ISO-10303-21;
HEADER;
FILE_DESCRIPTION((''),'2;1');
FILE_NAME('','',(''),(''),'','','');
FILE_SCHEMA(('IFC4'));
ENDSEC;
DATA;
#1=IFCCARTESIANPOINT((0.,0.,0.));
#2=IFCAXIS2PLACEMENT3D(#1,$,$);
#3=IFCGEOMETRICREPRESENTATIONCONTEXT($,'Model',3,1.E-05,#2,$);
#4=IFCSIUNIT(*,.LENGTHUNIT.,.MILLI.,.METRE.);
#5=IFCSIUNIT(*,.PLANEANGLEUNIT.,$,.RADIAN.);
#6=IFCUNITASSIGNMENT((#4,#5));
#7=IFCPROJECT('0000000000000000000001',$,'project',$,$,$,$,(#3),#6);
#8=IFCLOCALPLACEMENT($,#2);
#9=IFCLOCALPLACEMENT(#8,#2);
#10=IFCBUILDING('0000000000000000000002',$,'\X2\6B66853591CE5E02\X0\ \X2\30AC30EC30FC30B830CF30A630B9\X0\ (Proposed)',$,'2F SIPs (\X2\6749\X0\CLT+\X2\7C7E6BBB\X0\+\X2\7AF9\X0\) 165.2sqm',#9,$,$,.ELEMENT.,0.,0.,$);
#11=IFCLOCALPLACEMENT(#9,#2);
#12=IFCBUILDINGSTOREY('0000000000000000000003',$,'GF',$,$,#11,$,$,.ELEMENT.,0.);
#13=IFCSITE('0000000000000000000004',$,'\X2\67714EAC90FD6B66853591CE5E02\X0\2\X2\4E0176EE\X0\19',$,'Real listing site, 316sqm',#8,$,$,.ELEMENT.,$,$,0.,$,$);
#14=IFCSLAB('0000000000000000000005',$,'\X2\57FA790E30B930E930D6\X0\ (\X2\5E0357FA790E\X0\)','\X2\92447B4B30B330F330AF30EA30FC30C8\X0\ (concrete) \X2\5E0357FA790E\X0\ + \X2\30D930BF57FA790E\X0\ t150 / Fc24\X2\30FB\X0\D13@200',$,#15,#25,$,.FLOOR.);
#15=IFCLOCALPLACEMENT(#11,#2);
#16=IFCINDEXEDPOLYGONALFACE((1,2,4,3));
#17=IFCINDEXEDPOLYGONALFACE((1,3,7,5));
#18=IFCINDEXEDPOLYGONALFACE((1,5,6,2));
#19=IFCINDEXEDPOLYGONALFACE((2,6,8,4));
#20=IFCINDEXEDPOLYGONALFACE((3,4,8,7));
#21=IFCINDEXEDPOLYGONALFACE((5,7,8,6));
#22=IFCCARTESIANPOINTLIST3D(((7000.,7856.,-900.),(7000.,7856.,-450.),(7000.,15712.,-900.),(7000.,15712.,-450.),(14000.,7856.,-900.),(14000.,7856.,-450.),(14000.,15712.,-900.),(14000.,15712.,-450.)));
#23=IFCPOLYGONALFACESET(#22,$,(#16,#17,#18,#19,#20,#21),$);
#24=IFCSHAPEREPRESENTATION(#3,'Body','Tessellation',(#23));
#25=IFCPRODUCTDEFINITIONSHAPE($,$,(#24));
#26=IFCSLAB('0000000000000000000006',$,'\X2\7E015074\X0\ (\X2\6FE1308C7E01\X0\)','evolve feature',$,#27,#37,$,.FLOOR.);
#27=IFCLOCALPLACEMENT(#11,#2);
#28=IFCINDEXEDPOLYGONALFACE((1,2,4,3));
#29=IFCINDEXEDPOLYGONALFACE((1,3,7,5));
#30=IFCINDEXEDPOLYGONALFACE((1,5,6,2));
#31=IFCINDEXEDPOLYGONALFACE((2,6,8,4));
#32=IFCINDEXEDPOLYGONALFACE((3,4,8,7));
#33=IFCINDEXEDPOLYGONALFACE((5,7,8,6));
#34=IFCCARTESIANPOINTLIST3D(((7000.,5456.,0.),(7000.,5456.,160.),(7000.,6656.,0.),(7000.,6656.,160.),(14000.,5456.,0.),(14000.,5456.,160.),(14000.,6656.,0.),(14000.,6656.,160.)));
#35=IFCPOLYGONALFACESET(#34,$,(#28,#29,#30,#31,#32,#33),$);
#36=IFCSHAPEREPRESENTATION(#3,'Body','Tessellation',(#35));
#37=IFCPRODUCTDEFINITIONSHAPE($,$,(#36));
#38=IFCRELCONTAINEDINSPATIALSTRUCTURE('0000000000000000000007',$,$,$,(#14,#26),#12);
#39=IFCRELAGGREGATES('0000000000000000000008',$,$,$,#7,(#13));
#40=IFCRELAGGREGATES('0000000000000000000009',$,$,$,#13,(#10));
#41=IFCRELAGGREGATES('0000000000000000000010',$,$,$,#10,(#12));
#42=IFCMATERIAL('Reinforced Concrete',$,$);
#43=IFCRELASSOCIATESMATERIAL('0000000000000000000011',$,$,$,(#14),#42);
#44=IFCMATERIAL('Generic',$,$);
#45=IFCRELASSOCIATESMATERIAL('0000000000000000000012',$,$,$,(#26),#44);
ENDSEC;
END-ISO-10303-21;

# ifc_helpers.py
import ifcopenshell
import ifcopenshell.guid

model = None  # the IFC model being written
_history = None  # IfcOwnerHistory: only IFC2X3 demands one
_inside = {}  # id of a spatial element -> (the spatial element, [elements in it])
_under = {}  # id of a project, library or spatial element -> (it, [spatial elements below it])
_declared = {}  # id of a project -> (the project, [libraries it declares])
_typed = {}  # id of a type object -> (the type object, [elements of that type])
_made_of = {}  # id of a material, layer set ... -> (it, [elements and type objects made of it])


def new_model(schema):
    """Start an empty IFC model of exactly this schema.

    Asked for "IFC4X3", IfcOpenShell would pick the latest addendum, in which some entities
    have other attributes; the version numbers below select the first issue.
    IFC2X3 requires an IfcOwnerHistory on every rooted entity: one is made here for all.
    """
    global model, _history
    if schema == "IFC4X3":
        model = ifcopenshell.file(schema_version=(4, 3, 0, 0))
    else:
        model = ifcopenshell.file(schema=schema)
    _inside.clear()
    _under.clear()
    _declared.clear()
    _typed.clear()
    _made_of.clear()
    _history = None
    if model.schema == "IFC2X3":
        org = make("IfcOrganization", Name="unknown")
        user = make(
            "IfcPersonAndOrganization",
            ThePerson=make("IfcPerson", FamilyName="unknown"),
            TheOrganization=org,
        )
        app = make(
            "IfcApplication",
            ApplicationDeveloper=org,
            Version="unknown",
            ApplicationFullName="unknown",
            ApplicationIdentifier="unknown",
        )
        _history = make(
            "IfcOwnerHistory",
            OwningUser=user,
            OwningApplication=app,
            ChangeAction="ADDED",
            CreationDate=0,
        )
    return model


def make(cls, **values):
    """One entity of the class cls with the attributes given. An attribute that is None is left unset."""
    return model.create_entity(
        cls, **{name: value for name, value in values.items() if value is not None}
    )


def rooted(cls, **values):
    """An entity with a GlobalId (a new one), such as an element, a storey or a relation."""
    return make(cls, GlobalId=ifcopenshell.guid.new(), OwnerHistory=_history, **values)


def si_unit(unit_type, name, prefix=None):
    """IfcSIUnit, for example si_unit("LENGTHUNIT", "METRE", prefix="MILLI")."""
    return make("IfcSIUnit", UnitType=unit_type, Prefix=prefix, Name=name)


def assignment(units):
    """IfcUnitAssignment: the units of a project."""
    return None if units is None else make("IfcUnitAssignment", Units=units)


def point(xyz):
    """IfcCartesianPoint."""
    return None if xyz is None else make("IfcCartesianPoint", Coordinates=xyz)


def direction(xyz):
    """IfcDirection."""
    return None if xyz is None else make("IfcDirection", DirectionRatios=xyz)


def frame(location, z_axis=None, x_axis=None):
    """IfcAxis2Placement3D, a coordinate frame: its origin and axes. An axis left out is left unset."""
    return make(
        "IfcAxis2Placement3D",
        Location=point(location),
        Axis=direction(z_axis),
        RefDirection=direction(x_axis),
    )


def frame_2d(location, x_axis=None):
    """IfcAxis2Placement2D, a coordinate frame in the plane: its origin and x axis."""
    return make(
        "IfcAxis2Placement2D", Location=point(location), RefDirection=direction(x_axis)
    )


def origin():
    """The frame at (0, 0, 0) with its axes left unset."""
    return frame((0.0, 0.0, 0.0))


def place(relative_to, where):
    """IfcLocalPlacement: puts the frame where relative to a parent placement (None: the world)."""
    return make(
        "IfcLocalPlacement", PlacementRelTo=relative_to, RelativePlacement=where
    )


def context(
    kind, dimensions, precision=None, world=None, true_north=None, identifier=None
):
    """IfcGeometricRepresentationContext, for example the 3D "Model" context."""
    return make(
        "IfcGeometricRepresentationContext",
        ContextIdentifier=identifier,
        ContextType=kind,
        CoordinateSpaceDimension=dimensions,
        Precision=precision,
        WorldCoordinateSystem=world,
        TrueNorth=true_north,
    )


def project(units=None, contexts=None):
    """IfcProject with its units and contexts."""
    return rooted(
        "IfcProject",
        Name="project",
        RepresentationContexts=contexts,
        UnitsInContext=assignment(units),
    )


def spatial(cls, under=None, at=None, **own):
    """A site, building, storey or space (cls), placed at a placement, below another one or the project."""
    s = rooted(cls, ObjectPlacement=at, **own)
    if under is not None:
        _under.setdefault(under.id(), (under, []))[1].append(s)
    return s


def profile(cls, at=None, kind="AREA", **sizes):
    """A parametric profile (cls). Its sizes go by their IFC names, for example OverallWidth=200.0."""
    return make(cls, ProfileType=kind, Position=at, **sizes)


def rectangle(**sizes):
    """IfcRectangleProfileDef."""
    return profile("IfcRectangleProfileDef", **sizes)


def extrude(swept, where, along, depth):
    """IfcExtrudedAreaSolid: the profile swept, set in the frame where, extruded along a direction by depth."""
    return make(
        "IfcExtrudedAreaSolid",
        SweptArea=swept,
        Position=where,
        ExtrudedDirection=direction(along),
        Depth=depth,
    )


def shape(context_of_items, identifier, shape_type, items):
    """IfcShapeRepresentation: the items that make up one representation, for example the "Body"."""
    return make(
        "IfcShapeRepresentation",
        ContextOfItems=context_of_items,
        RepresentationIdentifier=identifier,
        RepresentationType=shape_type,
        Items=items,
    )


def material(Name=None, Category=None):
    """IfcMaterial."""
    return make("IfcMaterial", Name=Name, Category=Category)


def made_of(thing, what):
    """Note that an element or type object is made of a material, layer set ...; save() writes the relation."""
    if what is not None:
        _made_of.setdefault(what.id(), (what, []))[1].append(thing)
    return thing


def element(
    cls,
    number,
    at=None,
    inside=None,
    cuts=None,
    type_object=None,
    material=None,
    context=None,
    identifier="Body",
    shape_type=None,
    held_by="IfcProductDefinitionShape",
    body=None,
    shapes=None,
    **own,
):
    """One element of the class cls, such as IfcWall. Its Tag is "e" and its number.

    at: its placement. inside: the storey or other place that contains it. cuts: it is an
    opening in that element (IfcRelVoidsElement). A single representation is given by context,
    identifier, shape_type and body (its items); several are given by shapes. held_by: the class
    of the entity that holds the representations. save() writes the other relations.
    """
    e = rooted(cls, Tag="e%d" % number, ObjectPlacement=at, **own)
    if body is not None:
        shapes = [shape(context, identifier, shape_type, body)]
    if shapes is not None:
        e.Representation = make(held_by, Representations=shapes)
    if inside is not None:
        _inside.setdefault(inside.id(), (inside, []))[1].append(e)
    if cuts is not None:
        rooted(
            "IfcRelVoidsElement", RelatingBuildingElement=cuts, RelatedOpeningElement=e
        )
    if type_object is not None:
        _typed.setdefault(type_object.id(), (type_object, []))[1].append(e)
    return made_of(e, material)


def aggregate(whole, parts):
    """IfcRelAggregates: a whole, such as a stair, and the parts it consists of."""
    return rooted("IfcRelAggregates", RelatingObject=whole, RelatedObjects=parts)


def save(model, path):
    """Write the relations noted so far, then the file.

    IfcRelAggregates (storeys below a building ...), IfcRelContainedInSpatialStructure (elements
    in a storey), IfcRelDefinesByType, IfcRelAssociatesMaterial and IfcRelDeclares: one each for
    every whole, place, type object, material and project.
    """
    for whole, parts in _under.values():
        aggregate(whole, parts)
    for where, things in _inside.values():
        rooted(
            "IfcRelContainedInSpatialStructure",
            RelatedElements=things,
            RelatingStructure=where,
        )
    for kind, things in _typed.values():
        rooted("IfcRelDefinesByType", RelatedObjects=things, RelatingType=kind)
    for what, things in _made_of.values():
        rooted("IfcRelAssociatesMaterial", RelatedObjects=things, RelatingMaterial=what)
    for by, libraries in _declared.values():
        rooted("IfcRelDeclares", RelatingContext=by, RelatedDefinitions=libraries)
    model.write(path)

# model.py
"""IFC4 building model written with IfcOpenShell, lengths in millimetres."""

from ifc_helpers import new_model, si_unit, frame, frame_2d, origin, place, context, project, spatial, rectangle, extrude, material, element, save


model = new_model("IFC4")

# Units and contexts
model_context = context("Model", 3, precision=1e-05, world=origin())
ifc_project = project(units=[si_unit("LENGTHUNIT", "METRE", prefix="MILLI"), si_unit("PLANEANGLEUNIT", "RADIAN")], contexts=[model_context])

# Site, building, storey
site_placement = place(None, origin())
site = spatial("IfcSite", under=ifc_project, at=site_placement, Name="東京都武蔵野市2丁目19", ObjectType="Real listing site, 316sqm", CompositionType="ELEMENT", RefElevation=0.0)
building_placement = place(site_placement, origin())
building = spatial("IfcBuilding", under=site, at=building_placement, Name="武蔵野市 ガレージハウス (Proposed)", ObjectType="2F SIPs (杉CLT+籾殻+竹) 165.2sqm", CompositionType="ELEMENT", ElevationOfRefHeight=0.0, ElevationOfTerrain=0.0)
storey_placement = place(building_placement, origin())
storey = spatial("IfcBuildingStorey", under=building, at=storey_placement, Name="GF", CompositionType="ELEMENT", Elevation=0.0)

# Slabs
ifc_material_1 = material(Name="Reinforced Concrete")
slab_1_placement = place(storey_placement, frame((3500.0, 3928.0, -450.0)))
element("IfcSlab", 1, at=slab_1_placement, inside=storey, material=ifc_material_1, Name="基礎スラブ (布基礎)", Description="鉄筋コンクリート (concrete) 布基礎 + ベタ基礎 t150 / Fc24・D13@200", PredefinedType="FLOOR", context=model_context, shape_type="SweptSolid", body=[
    extrude(rectangle(XDim=7000.0, YDim=7856.0, at=frame_2d((3500.0, 3928.0))), frame((3500.0, 3928.0, -450.0)), (0.0, 0.0, 1.0), 450.0),
])
ifc_material_2 = material(Name="Generic")
slab_2_placement = place(storey_placement, frame((3500.0, 2728.0, 0.0)))
element("IfcSlab", 2, at=slab_2_placement, inside=storey, material=ifc_material_2, Name="縁側 (濡れ縁)", Description="evolve feature", PredefinedType="FLOOR", context=model_context, shape_type="SweptSolid", body=[
    extrude(rectangle(XDim=7000.0, YDim=1200.0, at=frame_2d((3500.0, 600.0))), frame((3500.0, 2728.0, 0.0)), (0.0, 0.0, 1.0), 160.0),
])

save(model, "model.ifc")
